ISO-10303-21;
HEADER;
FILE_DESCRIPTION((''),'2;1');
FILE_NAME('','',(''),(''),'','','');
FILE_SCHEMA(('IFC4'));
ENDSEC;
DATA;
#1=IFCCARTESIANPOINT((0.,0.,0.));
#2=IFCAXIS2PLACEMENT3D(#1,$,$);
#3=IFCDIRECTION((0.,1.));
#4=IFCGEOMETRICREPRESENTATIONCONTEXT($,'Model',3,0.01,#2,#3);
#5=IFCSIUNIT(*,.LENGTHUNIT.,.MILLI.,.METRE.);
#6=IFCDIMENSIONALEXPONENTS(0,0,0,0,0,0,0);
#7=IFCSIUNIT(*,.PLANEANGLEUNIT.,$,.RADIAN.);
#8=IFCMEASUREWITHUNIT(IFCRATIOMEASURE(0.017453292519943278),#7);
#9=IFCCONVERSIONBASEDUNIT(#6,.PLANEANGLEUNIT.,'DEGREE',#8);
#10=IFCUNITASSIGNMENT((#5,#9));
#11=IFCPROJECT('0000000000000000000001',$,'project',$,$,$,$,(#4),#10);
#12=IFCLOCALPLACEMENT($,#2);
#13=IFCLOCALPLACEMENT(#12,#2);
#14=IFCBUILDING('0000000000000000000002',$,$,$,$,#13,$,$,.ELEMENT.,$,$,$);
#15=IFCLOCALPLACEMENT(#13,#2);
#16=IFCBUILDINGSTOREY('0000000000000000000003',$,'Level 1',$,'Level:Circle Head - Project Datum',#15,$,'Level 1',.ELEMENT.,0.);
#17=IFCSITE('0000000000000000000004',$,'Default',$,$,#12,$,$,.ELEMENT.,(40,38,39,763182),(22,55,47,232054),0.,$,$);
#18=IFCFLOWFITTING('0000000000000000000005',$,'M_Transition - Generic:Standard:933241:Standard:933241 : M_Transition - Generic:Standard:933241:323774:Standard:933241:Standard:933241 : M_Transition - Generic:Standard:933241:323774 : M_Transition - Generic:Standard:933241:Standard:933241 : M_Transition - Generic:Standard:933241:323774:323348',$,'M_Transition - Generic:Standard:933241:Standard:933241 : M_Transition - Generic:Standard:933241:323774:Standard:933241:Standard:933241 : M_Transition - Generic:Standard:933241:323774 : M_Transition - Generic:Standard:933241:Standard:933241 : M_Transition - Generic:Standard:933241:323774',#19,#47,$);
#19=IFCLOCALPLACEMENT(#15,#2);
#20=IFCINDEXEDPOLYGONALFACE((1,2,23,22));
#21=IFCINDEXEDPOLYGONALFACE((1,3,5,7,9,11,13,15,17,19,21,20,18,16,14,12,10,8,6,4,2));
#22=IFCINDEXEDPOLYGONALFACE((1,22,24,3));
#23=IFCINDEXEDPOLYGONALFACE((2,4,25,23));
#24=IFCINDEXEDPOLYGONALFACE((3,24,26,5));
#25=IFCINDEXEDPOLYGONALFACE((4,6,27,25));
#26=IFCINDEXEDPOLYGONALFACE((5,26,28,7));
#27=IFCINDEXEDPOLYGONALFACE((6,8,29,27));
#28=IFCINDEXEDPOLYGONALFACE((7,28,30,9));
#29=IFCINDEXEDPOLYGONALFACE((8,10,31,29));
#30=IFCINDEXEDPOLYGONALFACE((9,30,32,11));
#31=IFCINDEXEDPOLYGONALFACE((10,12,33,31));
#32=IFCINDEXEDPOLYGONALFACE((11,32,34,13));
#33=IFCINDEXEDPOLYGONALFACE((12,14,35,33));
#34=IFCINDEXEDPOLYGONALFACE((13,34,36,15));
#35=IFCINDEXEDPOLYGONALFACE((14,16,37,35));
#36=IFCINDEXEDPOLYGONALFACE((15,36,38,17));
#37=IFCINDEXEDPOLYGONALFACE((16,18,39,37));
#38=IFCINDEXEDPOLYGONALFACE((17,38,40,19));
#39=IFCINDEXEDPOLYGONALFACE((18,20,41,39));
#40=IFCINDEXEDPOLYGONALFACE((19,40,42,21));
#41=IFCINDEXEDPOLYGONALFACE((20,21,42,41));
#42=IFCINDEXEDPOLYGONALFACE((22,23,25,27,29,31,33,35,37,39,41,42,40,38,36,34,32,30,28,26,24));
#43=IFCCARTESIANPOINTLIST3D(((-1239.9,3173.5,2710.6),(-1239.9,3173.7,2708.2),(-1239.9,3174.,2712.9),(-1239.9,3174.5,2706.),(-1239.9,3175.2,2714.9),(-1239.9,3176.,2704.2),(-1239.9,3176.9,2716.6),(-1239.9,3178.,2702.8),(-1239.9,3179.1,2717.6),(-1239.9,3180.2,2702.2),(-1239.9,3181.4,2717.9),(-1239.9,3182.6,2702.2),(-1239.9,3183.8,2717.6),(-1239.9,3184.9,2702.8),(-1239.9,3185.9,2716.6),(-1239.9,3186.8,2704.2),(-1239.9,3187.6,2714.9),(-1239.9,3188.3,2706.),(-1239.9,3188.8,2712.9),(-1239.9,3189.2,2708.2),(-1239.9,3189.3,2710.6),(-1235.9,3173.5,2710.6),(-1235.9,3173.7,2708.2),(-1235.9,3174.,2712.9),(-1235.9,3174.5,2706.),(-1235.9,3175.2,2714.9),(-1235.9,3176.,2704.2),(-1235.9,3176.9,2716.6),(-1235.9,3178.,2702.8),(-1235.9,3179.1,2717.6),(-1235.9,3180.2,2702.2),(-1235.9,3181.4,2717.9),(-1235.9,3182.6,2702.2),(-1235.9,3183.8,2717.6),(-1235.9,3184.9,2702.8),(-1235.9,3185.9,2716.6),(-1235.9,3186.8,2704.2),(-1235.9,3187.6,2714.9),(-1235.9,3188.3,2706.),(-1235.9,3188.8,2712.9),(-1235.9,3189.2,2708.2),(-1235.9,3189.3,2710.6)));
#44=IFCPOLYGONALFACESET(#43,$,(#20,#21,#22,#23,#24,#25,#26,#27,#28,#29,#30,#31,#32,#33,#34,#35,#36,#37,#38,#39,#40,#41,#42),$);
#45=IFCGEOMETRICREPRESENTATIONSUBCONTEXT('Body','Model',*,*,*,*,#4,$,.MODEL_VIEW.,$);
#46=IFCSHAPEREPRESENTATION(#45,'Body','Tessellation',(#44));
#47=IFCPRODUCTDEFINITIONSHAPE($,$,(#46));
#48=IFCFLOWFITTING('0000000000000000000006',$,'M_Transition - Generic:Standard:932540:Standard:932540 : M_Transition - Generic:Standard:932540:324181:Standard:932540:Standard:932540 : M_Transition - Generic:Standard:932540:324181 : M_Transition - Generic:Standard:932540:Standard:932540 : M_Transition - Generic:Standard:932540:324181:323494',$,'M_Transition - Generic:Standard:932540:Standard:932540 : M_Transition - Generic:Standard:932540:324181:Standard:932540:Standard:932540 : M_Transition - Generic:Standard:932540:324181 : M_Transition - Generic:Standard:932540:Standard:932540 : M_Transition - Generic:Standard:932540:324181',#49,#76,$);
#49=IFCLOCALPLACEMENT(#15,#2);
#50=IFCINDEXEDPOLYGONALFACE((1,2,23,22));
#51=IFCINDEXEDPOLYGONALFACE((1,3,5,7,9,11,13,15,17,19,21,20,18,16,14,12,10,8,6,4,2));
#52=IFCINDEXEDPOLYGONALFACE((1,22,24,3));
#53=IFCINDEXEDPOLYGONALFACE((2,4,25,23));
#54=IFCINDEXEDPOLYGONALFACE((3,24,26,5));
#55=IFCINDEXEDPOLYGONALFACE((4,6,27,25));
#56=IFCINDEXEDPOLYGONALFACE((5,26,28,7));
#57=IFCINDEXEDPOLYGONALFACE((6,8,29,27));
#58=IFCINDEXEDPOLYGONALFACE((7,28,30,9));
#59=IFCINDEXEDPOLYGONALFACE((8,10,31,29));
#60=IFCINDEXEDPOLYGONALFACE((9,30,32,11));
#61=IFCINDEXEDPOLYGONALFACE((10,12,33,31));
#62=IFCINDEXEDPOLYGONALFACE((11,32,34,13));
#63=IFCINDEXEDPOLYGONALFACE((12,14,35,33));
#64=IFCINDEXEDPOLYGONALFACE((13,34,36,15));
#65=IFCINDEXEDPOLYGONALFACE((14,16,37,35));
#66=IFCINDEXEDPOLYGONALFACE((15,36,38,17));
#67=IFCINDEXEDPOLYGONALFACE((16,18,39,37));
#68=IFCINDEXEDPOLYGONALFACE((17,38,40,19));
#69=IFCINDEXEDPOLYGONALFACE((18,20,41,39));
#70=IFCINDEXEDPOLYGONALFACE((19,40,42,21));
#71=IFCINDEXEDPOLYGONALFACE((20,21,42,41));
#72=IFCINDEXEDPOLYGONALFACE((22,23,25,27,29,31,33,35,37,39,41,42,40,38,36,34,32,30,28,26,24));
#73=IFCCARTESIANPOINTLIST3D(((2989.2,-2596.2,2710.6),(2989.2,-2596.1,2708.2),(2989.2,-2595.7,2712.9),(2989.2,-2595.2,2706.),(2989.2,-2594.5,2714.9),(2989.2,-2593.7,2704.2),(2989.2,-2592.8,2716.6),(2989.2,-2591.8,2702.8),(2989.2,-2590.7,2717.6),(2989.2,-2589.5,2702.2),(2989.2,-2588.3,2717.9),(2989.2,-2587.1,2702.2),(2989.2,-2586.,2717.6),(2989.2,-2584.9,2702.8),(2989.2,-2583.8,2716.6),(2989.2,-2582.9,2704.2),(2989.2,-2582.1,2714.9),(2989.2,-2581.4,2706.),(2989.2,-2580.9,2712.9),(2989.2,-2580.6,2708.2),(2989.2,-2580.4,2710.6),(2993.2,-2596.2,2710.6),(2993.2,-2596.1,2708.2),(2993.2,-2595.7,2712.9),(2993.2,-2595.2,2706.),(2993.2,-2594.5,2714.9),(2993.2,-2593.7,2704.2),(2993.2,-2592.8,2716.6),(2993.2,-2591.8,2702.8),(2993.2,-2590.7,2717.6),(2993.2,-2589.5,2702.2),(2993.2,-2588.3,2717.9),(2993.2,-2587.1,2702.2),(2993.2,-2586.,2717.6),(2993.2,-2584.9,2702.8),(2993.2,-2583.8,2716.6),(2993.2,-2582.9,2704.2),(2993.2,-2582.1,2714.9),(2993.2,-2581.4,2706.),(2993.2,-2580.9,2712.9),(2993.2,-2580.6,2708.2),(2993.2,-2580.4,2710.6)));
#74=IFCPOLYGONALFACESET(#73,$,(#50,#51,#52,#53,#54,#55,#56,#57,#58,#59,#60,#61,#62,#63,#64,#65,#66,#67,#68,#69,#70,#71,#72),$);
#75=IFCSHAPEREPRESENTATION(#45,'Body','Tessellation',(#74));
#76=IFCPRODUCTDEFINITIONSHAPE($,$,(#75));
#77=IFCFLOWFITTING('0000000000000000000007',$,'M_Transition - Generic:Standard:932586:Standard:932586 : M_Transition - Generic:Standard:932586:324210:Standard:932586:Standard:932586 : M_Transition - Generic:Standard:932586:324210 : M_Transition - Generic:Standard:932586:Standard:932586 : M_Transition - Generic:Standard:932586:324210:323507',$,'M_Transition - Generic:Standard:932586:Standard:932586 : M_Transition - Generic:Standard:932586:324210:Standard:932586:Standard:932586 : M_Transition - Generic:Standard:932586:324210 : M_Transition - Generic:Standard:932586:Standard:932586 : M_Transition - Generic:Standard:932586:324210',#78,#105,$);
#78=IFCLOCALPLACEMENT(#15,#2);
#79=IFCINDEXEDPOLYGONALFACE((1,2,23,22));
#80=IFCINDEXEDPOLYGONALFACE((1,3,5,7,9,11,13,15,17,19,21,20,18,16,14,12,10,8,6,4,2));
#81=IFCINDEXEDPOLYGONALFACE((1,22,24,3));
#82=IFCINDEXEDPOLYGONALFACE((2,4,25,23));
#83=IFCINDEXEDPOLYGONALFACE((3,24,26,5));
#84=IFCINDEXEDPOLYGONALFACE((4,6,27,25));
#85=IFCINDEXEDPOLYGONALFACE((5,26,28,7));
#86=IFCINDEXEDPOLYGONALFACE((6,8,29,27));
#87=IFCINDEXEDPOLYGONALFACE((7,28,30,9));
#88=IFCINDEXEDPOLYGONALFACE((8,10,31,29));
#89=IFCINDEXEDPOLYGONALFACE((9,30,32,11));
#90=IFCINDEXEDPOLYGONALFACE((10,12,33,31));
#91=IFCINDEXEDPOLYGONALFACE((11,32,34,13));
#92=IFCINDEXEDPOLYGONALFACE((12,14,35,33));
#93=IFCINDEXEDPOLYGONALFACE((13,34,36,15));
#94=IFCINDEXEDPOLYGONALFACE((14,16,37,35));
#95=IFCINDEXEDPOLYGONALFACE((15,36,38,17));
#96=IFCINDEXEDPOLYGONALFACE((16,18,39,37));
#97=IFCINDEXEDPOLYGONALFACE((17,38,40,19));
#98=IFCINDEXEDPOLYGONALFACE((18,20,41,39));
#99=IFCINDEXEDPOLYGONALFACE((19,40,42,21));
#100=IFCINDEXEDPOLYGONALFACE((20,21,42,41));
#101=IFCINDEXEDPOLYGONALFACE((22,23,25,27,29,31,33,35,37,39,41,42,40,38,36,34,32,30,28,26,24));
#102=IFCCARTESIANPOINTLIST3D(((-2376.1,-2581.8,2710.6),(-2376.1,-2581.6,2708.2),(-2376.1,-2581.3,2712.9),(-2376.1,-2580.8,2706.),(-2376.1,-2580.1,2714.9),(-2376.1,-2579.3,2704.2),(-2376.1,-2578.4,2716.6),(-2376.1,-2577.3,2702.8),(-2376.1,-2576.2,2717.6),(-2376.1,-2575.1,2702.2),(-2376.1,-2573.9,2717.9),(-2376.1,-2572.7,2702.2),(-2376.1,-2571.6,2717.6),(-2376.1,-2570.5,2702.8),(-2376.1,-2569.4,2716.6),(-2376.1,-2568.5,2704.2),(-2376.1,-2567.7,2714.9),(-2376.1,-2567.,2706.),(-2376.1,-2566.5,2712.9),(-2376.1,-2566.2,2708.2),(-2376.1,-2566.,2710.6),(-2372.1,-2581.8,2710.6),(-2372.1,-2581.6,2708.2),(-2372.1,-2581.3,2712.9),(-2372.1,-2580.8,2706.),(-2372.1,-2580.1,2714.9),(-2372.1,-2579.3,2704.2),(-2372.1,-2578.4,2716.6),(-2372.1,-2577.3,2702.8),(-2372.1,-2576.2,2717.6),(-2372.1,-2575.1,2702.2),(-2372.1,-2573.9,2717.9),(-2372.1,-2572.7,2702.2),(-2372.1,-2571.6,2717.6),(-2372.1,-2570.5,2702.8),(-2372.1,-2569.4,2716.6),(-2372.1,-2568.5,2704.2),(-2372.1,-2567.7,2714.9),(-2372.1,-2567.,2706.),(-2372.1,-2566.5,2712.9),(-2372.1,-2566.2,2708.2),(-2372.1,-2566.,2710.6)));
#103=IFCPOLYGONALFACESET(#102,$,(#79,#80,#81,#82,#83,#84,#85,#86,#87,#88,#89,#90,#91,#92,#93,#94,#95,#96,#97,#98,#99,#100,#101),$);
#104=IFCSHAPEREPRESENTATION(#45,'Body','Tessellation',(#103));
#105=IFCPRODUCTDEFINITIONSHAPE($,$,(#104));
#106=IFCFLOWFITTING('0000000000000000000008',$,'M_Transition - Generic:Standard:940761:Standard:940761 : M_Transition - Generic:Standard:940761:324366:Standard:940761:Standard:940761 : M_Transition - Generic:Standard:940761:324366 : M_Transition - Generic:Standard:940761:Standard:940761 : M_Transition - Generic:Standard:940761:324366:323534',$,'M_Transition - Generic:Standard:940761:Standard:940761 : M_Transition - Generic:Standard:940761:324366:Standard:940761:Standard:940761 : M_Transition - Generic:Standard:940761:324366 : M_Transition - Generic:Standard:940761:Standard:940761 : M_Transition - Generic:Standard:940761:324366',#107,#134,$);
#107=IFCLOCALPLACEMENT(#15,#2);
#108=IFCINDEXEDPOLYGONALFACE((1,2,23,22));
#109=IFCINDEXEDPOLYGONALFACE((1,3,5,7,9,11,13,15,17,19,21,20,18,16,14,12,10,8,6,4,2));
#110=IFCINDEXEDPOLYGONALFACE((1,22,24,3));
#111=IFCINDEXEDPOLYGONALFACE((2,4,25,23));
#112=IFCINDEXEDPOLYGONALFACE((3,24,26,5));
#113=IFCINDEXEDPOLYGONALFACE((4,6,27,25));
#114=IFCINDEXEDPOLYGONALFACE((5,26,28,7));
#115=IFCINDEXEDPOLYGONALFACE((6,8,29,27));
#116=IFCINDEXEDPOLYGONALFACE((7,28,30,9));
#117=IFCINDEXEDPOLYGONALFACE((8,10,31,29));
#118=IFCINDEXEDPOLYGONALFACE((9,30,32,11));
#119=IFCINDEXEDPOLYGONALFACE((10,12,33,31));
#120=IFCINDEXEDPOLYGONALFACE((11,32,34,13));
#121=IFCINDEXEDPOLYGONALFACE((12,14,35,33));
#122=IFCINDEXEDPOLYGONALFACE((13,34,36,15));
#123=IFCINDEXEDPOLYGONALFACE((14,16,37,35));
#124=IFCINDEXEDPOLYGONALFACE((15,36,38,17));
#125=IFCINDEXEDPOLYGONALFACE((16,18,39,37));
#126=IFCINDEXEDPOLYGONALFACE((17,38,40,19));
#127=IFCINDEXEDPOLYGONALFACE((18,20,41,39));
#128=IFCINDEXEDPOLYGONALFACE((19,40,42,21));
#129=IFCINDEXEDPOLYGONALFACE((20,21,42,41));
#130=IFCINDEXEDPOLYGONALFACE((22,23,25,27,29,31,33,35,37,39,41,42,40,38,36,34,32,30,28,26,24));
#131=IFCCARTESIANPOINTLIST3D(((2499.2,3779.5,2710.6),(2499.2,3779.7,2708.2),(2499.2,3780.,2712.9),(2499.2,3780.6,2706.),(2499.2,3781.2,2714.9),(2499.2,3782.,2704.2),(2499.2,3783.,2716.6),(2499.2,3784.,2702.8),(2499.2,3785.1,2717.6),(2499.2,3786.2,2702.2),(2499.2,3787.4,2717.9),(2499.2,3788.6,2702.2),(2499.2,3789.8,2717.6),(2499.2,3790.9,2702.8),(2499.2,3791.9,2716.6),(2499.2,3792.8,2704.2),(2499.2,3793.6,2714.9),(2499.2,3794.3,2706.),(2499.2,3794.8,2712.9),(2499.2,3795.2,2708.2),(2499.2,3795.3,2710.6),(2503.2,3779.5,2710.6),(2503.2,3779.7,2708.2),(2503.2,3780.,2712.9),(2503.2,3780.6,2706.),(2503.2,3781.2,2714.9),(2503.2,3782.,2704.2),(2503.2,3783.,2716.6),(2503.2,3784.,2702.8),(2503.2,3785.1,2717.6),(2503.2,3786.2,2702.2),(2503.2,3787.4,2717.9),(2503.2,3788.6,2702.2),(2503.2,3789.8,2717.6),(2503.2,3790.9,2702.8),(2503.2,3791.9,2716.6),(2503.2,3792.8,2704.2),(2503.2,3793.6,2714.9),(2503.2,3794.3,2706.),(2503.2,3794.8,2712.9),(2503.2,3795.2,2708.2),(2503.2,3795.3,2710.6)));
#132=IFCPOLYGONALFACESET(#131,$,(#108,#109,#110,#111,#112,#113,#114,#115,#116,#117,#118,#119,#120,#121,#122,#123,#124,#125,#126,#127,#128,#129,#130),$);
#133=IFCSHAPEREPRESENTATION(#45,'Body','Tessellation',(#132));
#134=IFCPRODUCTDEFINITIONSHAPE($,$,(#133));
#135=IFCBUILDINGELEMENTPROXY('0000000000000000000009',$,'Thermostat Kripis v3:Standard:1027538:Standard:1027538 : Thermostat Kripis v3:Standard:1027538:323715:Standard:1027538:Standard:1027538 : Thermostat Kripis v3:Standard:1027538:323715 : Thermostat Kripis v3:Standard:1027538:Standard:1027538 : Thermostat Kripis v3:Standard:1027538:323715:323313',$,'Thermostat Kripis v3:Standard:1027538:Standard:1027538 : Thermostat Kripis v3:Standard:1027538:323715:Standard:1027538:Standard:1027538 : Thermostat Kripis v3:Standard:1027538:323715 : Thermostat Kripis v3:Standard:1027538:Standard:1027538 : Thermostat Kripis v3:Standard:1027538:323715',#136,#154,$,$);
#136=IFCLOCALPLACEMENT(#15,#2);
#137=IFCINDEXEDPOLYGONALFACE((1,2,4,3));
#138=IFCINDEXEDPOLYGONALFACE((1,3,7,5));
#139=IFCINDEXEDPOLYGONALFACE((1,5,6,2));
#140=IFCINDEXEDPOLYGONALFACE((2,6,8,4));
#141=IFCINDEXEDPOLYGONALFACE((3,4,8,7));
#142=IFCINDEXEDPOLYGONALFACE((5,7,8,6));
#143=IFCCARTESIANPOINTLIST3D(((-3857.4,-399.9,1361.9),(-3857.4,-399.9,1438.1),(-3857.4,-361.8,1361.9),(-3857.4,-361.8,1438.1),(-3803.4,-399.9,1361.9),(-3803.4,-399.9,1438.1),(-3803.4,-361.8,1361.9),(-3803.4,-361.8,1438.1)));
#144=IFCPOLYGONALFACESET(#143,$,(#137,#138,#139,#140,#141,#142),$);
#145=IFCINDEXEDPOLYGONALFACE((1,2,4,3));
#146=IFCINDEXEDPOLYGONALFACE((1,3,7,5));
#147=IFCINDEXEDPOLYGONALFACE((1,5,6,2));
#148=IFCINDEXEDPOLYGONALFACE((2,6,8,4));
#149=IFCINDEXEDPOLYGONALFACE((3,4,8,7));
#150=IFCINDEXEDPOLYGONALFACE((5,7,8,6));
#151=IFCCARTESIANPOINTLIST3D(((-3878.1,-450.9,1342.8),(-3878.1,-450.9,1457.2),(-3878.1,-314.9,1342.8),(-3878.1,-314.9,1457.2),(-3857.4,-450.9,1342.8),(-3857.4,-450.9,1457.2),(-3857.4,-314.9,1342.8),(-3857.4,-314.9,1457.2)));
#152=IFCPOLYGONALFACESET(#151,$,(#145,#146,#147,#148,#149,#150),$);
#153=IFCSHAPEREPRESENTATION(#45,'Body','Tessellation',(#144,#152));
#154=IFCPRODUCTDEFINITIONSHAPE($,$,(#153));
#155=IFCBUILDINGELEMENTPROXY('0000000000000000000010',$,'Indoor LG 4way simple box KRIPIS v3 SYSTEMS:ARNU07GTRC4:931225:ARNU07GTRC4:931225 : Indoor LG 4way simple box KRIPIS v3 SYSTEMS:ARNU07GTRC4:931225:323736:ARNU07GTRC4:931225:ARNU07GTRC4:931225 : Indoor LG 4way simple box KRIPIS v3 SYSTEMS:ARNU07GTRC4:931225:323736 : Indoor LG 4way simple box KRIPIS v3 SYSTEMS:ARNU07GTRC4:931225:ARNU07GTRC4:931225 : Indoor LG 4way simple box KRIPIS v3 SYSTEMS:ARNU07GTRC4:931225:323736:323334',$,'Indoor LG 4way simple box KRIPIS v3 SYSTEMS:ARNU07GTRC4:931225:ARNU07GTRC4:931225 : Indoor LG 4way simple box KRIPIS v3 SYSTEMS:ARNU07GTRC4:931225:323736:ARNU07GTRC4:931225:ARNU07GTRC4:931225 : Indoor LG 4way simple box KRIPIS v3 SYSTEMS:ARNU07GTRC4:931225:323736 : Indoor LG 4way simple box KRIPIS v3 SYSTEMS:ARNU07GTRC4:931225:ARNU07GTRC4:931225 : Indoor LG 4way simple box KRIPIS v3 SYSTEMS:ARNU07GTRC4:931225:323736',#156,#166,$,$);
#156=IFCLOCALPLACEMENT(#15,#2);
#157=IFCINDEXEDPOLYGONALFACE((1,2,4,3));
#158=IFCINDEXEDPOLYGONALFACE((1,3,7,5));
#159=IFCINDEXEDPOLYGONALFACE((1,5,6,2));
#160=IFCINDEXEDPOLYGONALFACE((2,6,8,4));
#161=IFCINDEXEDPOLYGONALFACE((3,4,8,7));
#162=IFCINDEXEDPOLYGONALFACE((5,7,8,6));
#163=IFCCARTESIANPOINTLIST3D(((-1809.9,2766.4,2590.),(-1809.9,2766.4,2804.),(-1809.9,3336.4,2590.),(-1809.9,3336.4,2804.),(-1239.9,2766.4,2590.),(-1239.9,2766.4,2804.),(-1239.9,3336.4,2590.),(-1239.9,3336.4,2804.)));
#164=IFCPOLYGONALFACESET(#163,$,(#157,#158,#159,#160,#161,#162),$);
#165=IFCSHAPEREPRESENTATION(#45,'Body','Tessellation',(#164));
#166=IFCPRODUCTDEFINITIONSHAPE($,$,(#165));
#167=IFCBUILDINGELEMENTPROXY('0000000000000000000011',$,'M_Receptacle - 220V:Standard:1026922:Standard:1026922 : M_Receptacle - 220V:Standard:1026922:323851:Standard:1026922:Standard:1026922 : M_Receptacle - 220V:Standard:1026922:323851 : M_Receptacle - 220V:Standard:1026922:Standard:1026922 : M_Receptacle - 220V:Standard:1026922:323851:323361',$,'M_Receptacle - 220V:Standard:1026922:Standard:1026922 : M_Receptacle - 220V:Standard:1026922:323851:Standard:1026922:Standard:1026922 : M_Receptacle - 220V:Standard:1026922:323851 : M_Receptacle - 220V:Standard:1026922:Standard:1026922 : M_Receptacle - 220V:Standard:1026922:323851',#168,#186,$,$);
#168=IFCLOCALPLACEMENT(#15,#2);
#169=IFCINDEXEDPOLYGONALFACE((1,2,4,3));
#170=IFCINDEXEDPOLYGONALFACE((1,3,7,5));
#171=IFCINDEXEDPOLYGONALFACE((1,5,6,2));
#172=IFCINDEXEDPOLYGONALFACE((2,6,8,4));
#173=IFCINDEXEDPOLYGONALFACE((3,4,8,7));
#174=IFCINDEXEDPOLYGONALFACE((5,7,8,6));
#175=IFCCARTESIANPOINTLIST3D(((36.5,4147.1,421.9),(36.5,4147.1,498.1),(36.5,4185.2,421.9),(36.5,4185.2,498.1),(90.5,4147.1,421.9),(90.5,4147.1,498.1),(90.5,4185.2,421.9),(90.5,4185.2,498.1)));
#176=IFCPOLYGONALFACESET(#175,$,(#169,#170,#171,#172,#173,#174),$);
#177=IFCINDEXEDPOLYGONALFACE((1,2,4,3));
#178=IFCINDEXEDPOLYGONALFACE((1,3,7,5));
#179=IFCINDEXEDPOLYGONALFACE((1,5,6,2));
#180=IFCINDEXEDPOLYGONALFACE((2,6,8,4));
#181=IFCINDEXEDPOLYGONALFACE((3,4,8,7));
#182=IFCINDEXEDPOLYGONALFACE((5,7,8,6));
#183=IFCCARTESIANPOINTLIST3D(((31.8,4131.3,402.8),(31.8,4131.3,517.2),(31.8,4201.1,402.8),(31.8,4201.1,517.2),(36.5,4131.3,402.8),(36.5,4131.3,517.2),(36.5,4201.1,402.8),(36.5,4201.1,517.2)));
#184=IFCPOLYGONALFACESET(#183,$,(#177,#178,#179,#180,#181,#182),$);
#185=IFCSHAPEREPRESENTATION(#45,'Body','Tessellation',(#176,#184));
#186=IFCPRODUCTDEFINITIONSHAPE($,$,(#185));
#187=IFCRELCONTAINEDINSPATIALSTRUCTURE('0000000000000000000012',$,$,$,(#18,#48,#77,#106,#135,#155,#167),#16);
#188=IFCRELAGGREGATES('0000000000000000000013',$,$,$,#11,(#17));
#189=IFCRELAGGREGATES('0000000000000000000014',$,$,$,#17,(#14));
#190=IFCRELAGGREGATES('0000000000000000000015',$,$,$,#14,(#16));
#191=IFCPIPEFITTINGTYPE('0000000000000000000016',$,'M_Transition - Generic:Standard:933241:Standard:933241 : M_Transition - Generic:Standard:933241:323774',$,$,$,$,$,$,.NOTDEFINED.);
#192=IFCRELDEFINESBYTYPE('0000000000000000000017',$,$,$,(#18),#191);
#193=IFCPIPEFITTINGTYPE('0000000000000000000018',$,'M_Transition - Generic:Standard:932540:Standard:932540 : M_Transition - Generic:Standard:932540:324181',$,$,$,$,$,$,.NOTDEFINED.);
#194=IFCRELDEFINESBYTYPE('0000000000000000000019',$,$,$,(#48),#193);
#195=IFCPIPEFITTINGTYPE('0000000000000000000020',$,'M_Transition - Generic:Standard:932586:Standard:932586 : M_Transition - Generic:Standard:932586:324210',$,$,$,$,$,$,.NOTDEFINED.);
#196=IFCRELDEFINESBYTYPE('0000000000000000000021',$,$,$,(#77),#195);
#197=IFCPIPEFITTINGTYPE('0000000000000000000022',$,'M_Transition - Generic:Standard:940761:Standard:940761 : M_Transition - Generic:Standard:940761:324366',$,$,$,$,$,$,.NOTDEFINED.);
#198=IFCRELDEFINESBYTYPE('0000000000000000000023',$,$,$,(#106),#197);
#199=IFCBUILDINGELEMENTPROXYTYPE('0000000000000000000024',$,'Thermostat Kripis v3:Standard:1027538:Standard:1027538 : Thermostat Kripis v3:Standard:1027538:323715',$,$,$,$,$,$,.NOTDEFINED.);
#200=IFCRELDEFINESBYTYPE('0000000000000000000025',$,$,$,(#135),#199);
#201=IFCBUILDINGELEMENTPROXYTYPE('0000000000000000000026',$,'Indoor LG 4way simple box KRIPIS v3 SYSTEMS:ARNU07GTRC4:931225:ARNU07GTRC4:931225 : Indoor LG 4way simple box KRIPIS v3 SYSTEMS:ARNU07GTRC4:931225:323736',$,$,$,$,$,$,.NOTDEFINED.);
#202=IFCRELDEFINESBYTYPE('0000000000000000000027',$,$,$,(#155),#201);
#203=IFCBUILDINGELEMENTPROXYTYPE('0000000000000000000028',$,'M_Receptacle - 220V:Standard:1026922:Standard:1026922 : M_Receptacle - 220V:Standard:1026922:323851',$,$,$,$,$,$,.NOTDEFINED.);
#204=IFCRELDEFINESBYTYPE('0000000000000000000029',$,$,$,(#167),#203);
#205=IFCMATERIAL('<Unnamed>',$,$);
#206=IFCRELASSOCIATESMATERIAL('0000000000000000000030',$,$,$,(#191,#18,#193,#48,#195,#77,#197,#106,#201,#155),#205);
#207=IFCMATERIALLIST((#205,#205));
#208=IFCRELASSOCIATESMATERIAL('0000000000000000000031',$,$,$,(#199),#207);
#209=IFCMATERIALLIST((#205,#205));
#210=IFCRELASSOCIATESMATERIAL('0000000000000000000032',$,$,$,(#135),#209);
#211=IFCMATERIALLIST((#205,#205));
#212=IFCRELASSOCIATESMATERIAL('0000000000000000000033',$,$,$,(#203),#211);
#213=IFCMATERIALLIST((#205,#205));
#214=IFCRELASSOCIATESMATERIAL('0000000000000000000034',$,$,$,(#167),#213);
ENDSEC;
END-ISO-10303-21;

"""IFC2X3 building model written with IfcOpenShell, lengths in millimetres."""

from ifc_helpers import new_model, entity, si_unit, converted_unit, direction, frame, frame_2d, origin, origin_2d_with_axis, place, context, subcontext, project, spatial, rectangle, circle, extrude, source, transform, mapped, material, material_list, type_object, type_shapes, element, save


model = new_model("IFC2X3")

# Units and contexts
model_context = context("Model", 3, precision=0.01, world=origin(), true_north=direction((0.0, 1.0)))
body_context = subcontext(model_context, "Body", "Model", "MODEL_VIEW")
ifc_project = project(units=[si_unit("LENGTHUNIT", "METRE", prefix="MILLI"), converted_unit("PLANEANGLEUNIT", "DEGREE", entity("IfcRatioMeasure", 0.017453292519943278), si_unit("PLANEANGLEUNIT", "RADIAN"), dimensions=[0, 0, 0, 0, 0, 0, 0])], contexts=[model_context])

# Site, building, storey
site_placement = place(None, origin())
site = spatial("IfcSite", under=ifc_project, at=site_placement, Name="Default", CompositionType="ELEMENT", RefLatitude=(40, 38, 39, 763182), RefLongitude=(22, 55, 47, 232054), RefElevation=0.0)
building_placement = place(site_placement, origin())
building = spatial("IfcBuilding", under=site, at=building_placement, CompositionType="ELEMENT")
storey_placement = place(building_placement, origin())
storey = spatial("IfcBuildingStorey", under=building, at=storey_placement, Name="Level 1", ObjectType="Level:Circle Head - Project Datum", LongName="Level 1", CompositionType="ELEMENT", Elevation=0.0)

# Flow fittings
ifc_material_1 = material(Name="<Unnamed>")
pipe_fitting_type_1 = type_object("IfcPipeFittingType", Name="M_Transition - Generic:Standard:933241:Standard:933241 : M_Transition - Generic:Standard:933241:323774", PredefinedType="NOTDEFINED", material=ifc_material_1)
shared_shape_1 = source(origin(), body_context, "Body", "SweptSolid", [
    extrude(circle(Radius=7.9, at=origin_2d_with_axis()), frame((-1239.9, 3181.4, 2710.0), z_axis=(1.0, 0.0, 0.0), x_axis=(0.0, 0.0, 1.0)), (0.0, 0.0, 1.0), 4.0),
])
type_shapes(pipe_fitting_type_1, [shared_shape_1])
flow_fitting_1_placement = place(storey_placement, origin())
element("IfcFlowFitting", 1, at=flow_fitting_1_placement, inside=storey, type_object=pipe_fitting_type_1, material=ifc_material_1, Name="M_Transition - Generic:Standard:933241:Standard:933241 : M_Transition - Generic:Standard:933241:323774:Standard:933241:Standard:933241 : M_Transition - Generic:Standard:933241:323774 : M_Transition - Generic:Standard:933241:Standard:933241 : M_Transition - Generic:Standard:933241:323774:323348", ObjectType="M_Transition - Generic:Standard:933241:Standard:933241 : M_Transition - Generic:Standard:933241:323774:Standard:933241:Standard:933241 : M_Transition - Generic:Standard:933241:323774 : M_Transition - Generic:Standard:933241:Standard:933241 : M_Transition - Generic:Standard:933241:323774", context=body_context, shape_type="MappedRepresentation", body=[
    mapped(shared_shape_1, transform((0.0, 0.0, 0.0), scale=1.0)),
])
pipe_fitting_type_2 = type_object("IfcPipeFittingType", Name="M_Transition - Generic:Standard:932540:Standard:932540 : M_Transition - Generic:Standard:932540:324181", PredefinedType="NOTDEFINED", material=ifc_material_1)
shared_shape_2 = source(origin(), body_context, "Body", "SweptSolid", [
    extrude(circle(Radius=7.9, at=origin_2d_with_axis()), frame((2989.2, -2588.3, 2710.0), z_axis=(1.0, 0.0, 0.0), x_axis=(0.0, 0.0, 1.0)), (0.0, 0.0, 1.0), 4.0),
])
type_shapes(pipe_fitting_type_2, [shared_shape_2])
flow_fitting_2_placement = place(storey_placement, origin())
element("IfcFlowFitting", 2, at=flow_fitting_2_placement, inside=storey, type_object=pipe_fitting_type_2, material=ifc_material_1, Name="M_Transition - Generic:Standard:932540:Standard:932540 : M_Transition - Generic:Standard:932540:324181:Standard:932540:Standard:932540 : M_Transition - Generic:Standard:932540:324181 : M_Transition - Generic:Standard:932540:Standard:932540 : M_Transition - Generic:Standard:932540:324181:323494", ObjectType="M_Transition - Generic:Standard:932540:Standard:932540 : M_Transition - Generic:Standard:932540:324181:Standard:932540:Standard:932540 : M_Transition - Generic:Standard:932540:324181 : M_Transition - Generic:Standard:932540:Standard:932540 : M_Transition - Generic:Standard:932540:324181", context=body_context, shape_type="MappedRepresentation", body=[
    mapped(shared_shape_2, transform((0.0, 0.0, 0.0), scale=1.0)),
])
pipe_fitting_type_3 = type_object("IfcPipeFittingType", Name="M_Transition - Generic:Standard:932586:Standard:932586 : M_Transition - Generic:Standard:932586:324210", PredefinedType="NOTDEFINED", material=ifc_material_1)
shared_shape_3 = source(origin(), body_context, "Body", "SweptSolid", [
    extrude(circle(Radius=7.9, at=origin_2d_with_axis()), frame((-2376.1, -2573.9, 2710.0), z_axis=(1.0, 0.0, 0.0), x_axis=(0.0, 0.0, 1.0)), (0.0, 0.0, 1.0), 4.0),
])
type_shapes(pipe_fitting_type_3, [shared_shape_3])
flow_fitting_3_placement = place(storey_placement, origin())
element("IfcFlowFitting", 3, at=flow_fitting_3_placement, inside=storey, type_object=pipe_fitting_type_3, material=ifc_material_1, Name="M_Transition - Generic:Standard:932586:Standard:932586 : M_Transition - Generic:Standard:932586:324210:Standard:932586:Standard:932586 : M_Transition - Generic:Standard:932586:324210 : M_Transition - Generic:Standard:932586:Standard:932586 : M_Transition - Generic:Standard:932586:324210:323507", ObjectType="M_Transition - Generic:Standard:932586:Standard:932586 : M_Transition - Generic:Standard:932586:324210:Standard:932586:Standard:932586 : M_Transition - Generic:Standard:932586:324210 : M_Transition - Generic:Standard:932586:Standard:932586 : M_Transition - Generic:Standard:932586:324210", context=body_context, shape_type="MappedRepresentation", body=[
    mapped(shared_shape_3, transform((0.0, 0.0, 0.0), scale=1.0)),
])
pipe_fitting_type_4 = type_object("IfcPipeFittingType", Name="M_Transition - Generic:Standard:940761:Standard:940761 : M_Transition - Generic:Standard:940761:324366", PredefinedType="NOTDEFINED", material=ifc_material_1)
shared_shape_4 = source(origin(), body_context, "Body", "SweptSolid", [
    extrude(circle(Radius=7.9, at=origin_2d_with_axis()), frame((2499.2, 3787.4, 2710.0), z_axis=(1.0, 0.0, 0.0), x_axis=(0.0, 0.0, 1.0)), (0.0, 0.0, 1.0), 4.0),
])
type_shapes(pipe_fitting_type_4, [shared_shape_4])
flow_fitting_4_placement = place(storey_placement, origin())
element("IfcFlowFitting", 4, at=flow_fitting_4_placement, inside=storey, type_object=pipe_fitting_type_4, material=ifc_material_1, Name="M_Transition - Generic:Standard:940761:Standard:940761 : M_Transition - Generic:Standard:940761:324366:Standard:940761:Standard:940761 : M_Transition - Generic:Standard:940761:324366 : M_Transition - Generic:Standard:940761:Standard:940761 : M_Transition - Generic:Standard:940761:324366:323534", ObjectType="M_Transition - Generic:Standard:940761:Standard:940761 : M_Transition - Generic:Standard:940761:324366:Standard:940761:Standard:940761 : M_Transition - Generic:Standard:940761:324366 : M_Transition - Generic:Standard:940761:Standard:940761 : M_Transition - Generic:Standard:940761:324366", context=body_context, shape_type="MappedRepresentation", body=[
    mapped(shared_shape_4, transform((0.0, 0.0, 0.0), scale=1.0)),
])

# Building element proxies
ifc_material_list_1 = material_list([ifc_material_1, ifc_material_1])
ifc_material_list_2 = material_list([ifc_material_1, ifc_material_1])
building_element_proxy_type_1 = type_object("IfcBuildingElementProxyType", Name="Thermostat Kripis v3:Standard:1027538:Standard:1027538 : Thermostat Kripis v3:Standard:1027538:323715", PredefinedType="NOTDEFINED", material=ifc_material_list_2)
shared_shape_5 = source(origin(), body_context, "Body", "SweptSolid", [
    extrude(rectangle(XDim=38.1, YDim=54.0, at=frame_2d((0.0, 0.0), x_axis=(1.0, 0.0))), frame((-3830.4, -380.8, 1361.9), z_axis=(0.0, 0.0, 1.0), x_axis=(0.0, 1.0, 0.0)), (0.0, 0.0, 1.0), 76.2),
    extrude(rectangle(XDim=136.0, YDim=20.7, at=origin_2d_with_axis()), frame((-3867.7, -382.9, 1342.8), z_axis=(0.0, 0.0, 1.0), x_axis=(0.0, 1.0, 0.0)), (0.0, 0.0, 1.0), 114.3),
])
type_shapes(building_element_proxy_type_1, [shared_shape_5])
proxy_1_placement = place(storey_placement, origin())
element("IfcBuildingElementProxy", 5, at=proxy_1_placement, inside=storey, type_object=building_element_proxy_type_1, material=ifc_material_list_1, Name="Thermostat Kripis v3:Standard:1027538:Standard:1027538 : Thermostat Kripis v3:Standard:1027538:323715:Standard:1027538:Standard:1027538 : Thermostat Kripis v3:Standard:1027538:323715 : Thermostat Kripis v3:Standard:1027538:Standard:1027538 : Thermostat Kripis v3:Standard:1027538:323715:323313", ObjectType="Thermostat Kripis v3:Standard:1027538:Standard:1027538 : Thermostat Kripis v3:Standard:1027538:323715:Standard:1027538:Standard:1027538 : Thermostat Kripis v3:Standard:1027538:323715 : Thermostat Kripis v3:Standard:1027538:Standard:1027538 : Thermostat Kripis v3:Standard:1027538:323715", context=body_context, shape_type="MappedRepresentation", body=[
    mapped(shared_shape_5, transform((0.0, 0.0, 0.0), scale=1.0)),
])
building_element_proxy_type_2 = type_object("IfcBuildingElementProxyType", Name="Indoor LG 4way simple box KRIPIS v3 SYSTEMS:ARNU07GTRC4:931225:ARNU07GTRC4:931225 : Indoor LG 4way simple box KRIPIS v3 SYSTEMS:ARNU07GTRC4:931225:323736", PredefinedType="NOTDEFINED", material=ifc_material_1)
shared_shape_6 = source(origin(), body_context, "Body", "SweptSolid", [
    extrude(rectangle(XDim=570.0, YDim=570.0, at=origin_2d_with_axis()), frame((-1524.9, 3051.4, 2590.0), z_axis=(0.0, 0.0, 1.0), x_axis=(0.0, -1.0, 0.0)), (0.0, 0.0, 1.0), 214.0),
])
type_shapes(building_element_proxy_type_2, [shared_shape_6])
proxy_2_placement = place(storey_placement, origin())
element("IfcBuildingElementProxy", 6, at=proxy_2_placement, inside=storey, type_object=building_element_proxy_type_2, material=ifc_material_1, Name="Indoor LG 4way simple box KRIPIS v3 SYSTEMS:ARNU07GTRC4:931225:ARNU07GTRC4:931225 : Indoor LG 4way simple box KRIPIS v3 SYSTEMS:ARNU07GTRC4:931225:323736:ARNU07GTRC4:931225:ARNU07GTRC4:931225 : Indoor LG 4way simple box KRIPIS v3 SYSTEMS:ARNU07GTRC4:931225:323736 : Indoor LG 4way simple box KRIPIS v3 SYSTEMS:ARNU07GTRC4:931225:ARNU07GTRC4:931225 : Indoor LG 4way simple box KRIPIS v3 SYSTEMS:ARNU07GTRC4:931225:323736:323334", ObjectType="Indoor LG 4way simple box KRIPIS v3 SYSTEMS:ARNU07GTRC4:931225:ARNU07GTRC4:931225 : Indoor LG 4way simple box KRIPIS v3 SYSTEMS:ARNU07GTRC4:931225:323736:ARNU07GTRC4:931225:ARNU07GTRC4:931225 : Indoor LG 4way simple box KRIPIS v3 SYSTEMS:ARNU07GTRC4:931225:323736 : Indoor LG 4way simple box KRIPIS v3 SYSTEMS:ARNU07GTRC4:931225:ARNU07GTRC4:931225 : Indoor LG 4way simple box KRIPIS v3 SYSTEMS:ARNU07GTRC4:931225:323736", context=body_context, shape_type="MappedRepresentation", body=[
    mapped(shared_shape_6, transform((0.0, 0.0, 0.0), scale=1.0)),
])
ifc_material_list_3 = material_list([ifc_material_1, ifc_material_1])
ifc_material_list_4 = material_list([ifc_material_1, ifc_material_1])
building_element_proxy_type_3 = type_object("IfcBuildingElementProxyType", Name="M_Receptacle - 220V:Standard:1026922:Standard:1026922 : M_Receptacle - 220V:Standard:1026922:323851", PredefinedType="NOTDEFINED", material=ifc_material_list_4)
shared_shape_7 = source(origin(), body_context, "Body", "SweptSolid", [
    extrude(rectangle(XDim=38.1, YDim=54.0, at=origin_2d_with_axis()), frame((63.5, 4166.2, 421.9), z_axis=(0.0, 0.0, 1.0), x_axis=(0.0, 1.0, 0.0)), (0.0, 0.0, 1.0), 76.2),
    extrude(rectangle(XDim=69.8, YDim=4.8, at=frame_2d((0.0, 0.0), x_axis=(1.0, 0.0))), frame((34.2, 4166.2, 402.8), z_axis=(0.0, 0.0, 1.0), x_axis=(0.0, 1.0, 0.0)), (0.0, 0.0, 1.0), 114.3),
])
type_shapes(building_element_proxy_type_3, [shared_shape_7])
proxy_3_placement = place(storey_placement, origin())
element("IfcBuildingElementProxy", 7, at=proxy_3_placement, inside=storey, type_object=building_element_proxy_type_3, material=ifc_material_list_3, Name="M_Receptacle - 220V:Standard:1026922:Standard:1026922 : M_Receptacle - 220V:Standard:1026922:323851:Standard:1026922:Standard:1026922 : M_Receptacle - 220V:Standard:1026922:323851 : M_Receptacle - 220V:Standard:1026922:Standard:1026922 : M_Receptacle - 220V:Standard:1026922:323851:323361", ObjectType="M_Receptacle - 220V:Standard:1026922:Standard:1026922 : M_Receptacle - 220V:Standard:1026922:323851:Standard:1026922:Standard:1026922 : M_Receptacle - 220V:Standard:1026922:323851 : M_Receptacle - 220V:Standard:1026922:Standard:1026922 : M_Receptacle - 220V:Standard:1026922:323851", context=body_context, shape_type="MappedRepresentation", body=[
    mapped(shared_shape_7, transform((0.0, 0.0, 0.0), scale=1.0)),
])

save(model, "model.ifc")
